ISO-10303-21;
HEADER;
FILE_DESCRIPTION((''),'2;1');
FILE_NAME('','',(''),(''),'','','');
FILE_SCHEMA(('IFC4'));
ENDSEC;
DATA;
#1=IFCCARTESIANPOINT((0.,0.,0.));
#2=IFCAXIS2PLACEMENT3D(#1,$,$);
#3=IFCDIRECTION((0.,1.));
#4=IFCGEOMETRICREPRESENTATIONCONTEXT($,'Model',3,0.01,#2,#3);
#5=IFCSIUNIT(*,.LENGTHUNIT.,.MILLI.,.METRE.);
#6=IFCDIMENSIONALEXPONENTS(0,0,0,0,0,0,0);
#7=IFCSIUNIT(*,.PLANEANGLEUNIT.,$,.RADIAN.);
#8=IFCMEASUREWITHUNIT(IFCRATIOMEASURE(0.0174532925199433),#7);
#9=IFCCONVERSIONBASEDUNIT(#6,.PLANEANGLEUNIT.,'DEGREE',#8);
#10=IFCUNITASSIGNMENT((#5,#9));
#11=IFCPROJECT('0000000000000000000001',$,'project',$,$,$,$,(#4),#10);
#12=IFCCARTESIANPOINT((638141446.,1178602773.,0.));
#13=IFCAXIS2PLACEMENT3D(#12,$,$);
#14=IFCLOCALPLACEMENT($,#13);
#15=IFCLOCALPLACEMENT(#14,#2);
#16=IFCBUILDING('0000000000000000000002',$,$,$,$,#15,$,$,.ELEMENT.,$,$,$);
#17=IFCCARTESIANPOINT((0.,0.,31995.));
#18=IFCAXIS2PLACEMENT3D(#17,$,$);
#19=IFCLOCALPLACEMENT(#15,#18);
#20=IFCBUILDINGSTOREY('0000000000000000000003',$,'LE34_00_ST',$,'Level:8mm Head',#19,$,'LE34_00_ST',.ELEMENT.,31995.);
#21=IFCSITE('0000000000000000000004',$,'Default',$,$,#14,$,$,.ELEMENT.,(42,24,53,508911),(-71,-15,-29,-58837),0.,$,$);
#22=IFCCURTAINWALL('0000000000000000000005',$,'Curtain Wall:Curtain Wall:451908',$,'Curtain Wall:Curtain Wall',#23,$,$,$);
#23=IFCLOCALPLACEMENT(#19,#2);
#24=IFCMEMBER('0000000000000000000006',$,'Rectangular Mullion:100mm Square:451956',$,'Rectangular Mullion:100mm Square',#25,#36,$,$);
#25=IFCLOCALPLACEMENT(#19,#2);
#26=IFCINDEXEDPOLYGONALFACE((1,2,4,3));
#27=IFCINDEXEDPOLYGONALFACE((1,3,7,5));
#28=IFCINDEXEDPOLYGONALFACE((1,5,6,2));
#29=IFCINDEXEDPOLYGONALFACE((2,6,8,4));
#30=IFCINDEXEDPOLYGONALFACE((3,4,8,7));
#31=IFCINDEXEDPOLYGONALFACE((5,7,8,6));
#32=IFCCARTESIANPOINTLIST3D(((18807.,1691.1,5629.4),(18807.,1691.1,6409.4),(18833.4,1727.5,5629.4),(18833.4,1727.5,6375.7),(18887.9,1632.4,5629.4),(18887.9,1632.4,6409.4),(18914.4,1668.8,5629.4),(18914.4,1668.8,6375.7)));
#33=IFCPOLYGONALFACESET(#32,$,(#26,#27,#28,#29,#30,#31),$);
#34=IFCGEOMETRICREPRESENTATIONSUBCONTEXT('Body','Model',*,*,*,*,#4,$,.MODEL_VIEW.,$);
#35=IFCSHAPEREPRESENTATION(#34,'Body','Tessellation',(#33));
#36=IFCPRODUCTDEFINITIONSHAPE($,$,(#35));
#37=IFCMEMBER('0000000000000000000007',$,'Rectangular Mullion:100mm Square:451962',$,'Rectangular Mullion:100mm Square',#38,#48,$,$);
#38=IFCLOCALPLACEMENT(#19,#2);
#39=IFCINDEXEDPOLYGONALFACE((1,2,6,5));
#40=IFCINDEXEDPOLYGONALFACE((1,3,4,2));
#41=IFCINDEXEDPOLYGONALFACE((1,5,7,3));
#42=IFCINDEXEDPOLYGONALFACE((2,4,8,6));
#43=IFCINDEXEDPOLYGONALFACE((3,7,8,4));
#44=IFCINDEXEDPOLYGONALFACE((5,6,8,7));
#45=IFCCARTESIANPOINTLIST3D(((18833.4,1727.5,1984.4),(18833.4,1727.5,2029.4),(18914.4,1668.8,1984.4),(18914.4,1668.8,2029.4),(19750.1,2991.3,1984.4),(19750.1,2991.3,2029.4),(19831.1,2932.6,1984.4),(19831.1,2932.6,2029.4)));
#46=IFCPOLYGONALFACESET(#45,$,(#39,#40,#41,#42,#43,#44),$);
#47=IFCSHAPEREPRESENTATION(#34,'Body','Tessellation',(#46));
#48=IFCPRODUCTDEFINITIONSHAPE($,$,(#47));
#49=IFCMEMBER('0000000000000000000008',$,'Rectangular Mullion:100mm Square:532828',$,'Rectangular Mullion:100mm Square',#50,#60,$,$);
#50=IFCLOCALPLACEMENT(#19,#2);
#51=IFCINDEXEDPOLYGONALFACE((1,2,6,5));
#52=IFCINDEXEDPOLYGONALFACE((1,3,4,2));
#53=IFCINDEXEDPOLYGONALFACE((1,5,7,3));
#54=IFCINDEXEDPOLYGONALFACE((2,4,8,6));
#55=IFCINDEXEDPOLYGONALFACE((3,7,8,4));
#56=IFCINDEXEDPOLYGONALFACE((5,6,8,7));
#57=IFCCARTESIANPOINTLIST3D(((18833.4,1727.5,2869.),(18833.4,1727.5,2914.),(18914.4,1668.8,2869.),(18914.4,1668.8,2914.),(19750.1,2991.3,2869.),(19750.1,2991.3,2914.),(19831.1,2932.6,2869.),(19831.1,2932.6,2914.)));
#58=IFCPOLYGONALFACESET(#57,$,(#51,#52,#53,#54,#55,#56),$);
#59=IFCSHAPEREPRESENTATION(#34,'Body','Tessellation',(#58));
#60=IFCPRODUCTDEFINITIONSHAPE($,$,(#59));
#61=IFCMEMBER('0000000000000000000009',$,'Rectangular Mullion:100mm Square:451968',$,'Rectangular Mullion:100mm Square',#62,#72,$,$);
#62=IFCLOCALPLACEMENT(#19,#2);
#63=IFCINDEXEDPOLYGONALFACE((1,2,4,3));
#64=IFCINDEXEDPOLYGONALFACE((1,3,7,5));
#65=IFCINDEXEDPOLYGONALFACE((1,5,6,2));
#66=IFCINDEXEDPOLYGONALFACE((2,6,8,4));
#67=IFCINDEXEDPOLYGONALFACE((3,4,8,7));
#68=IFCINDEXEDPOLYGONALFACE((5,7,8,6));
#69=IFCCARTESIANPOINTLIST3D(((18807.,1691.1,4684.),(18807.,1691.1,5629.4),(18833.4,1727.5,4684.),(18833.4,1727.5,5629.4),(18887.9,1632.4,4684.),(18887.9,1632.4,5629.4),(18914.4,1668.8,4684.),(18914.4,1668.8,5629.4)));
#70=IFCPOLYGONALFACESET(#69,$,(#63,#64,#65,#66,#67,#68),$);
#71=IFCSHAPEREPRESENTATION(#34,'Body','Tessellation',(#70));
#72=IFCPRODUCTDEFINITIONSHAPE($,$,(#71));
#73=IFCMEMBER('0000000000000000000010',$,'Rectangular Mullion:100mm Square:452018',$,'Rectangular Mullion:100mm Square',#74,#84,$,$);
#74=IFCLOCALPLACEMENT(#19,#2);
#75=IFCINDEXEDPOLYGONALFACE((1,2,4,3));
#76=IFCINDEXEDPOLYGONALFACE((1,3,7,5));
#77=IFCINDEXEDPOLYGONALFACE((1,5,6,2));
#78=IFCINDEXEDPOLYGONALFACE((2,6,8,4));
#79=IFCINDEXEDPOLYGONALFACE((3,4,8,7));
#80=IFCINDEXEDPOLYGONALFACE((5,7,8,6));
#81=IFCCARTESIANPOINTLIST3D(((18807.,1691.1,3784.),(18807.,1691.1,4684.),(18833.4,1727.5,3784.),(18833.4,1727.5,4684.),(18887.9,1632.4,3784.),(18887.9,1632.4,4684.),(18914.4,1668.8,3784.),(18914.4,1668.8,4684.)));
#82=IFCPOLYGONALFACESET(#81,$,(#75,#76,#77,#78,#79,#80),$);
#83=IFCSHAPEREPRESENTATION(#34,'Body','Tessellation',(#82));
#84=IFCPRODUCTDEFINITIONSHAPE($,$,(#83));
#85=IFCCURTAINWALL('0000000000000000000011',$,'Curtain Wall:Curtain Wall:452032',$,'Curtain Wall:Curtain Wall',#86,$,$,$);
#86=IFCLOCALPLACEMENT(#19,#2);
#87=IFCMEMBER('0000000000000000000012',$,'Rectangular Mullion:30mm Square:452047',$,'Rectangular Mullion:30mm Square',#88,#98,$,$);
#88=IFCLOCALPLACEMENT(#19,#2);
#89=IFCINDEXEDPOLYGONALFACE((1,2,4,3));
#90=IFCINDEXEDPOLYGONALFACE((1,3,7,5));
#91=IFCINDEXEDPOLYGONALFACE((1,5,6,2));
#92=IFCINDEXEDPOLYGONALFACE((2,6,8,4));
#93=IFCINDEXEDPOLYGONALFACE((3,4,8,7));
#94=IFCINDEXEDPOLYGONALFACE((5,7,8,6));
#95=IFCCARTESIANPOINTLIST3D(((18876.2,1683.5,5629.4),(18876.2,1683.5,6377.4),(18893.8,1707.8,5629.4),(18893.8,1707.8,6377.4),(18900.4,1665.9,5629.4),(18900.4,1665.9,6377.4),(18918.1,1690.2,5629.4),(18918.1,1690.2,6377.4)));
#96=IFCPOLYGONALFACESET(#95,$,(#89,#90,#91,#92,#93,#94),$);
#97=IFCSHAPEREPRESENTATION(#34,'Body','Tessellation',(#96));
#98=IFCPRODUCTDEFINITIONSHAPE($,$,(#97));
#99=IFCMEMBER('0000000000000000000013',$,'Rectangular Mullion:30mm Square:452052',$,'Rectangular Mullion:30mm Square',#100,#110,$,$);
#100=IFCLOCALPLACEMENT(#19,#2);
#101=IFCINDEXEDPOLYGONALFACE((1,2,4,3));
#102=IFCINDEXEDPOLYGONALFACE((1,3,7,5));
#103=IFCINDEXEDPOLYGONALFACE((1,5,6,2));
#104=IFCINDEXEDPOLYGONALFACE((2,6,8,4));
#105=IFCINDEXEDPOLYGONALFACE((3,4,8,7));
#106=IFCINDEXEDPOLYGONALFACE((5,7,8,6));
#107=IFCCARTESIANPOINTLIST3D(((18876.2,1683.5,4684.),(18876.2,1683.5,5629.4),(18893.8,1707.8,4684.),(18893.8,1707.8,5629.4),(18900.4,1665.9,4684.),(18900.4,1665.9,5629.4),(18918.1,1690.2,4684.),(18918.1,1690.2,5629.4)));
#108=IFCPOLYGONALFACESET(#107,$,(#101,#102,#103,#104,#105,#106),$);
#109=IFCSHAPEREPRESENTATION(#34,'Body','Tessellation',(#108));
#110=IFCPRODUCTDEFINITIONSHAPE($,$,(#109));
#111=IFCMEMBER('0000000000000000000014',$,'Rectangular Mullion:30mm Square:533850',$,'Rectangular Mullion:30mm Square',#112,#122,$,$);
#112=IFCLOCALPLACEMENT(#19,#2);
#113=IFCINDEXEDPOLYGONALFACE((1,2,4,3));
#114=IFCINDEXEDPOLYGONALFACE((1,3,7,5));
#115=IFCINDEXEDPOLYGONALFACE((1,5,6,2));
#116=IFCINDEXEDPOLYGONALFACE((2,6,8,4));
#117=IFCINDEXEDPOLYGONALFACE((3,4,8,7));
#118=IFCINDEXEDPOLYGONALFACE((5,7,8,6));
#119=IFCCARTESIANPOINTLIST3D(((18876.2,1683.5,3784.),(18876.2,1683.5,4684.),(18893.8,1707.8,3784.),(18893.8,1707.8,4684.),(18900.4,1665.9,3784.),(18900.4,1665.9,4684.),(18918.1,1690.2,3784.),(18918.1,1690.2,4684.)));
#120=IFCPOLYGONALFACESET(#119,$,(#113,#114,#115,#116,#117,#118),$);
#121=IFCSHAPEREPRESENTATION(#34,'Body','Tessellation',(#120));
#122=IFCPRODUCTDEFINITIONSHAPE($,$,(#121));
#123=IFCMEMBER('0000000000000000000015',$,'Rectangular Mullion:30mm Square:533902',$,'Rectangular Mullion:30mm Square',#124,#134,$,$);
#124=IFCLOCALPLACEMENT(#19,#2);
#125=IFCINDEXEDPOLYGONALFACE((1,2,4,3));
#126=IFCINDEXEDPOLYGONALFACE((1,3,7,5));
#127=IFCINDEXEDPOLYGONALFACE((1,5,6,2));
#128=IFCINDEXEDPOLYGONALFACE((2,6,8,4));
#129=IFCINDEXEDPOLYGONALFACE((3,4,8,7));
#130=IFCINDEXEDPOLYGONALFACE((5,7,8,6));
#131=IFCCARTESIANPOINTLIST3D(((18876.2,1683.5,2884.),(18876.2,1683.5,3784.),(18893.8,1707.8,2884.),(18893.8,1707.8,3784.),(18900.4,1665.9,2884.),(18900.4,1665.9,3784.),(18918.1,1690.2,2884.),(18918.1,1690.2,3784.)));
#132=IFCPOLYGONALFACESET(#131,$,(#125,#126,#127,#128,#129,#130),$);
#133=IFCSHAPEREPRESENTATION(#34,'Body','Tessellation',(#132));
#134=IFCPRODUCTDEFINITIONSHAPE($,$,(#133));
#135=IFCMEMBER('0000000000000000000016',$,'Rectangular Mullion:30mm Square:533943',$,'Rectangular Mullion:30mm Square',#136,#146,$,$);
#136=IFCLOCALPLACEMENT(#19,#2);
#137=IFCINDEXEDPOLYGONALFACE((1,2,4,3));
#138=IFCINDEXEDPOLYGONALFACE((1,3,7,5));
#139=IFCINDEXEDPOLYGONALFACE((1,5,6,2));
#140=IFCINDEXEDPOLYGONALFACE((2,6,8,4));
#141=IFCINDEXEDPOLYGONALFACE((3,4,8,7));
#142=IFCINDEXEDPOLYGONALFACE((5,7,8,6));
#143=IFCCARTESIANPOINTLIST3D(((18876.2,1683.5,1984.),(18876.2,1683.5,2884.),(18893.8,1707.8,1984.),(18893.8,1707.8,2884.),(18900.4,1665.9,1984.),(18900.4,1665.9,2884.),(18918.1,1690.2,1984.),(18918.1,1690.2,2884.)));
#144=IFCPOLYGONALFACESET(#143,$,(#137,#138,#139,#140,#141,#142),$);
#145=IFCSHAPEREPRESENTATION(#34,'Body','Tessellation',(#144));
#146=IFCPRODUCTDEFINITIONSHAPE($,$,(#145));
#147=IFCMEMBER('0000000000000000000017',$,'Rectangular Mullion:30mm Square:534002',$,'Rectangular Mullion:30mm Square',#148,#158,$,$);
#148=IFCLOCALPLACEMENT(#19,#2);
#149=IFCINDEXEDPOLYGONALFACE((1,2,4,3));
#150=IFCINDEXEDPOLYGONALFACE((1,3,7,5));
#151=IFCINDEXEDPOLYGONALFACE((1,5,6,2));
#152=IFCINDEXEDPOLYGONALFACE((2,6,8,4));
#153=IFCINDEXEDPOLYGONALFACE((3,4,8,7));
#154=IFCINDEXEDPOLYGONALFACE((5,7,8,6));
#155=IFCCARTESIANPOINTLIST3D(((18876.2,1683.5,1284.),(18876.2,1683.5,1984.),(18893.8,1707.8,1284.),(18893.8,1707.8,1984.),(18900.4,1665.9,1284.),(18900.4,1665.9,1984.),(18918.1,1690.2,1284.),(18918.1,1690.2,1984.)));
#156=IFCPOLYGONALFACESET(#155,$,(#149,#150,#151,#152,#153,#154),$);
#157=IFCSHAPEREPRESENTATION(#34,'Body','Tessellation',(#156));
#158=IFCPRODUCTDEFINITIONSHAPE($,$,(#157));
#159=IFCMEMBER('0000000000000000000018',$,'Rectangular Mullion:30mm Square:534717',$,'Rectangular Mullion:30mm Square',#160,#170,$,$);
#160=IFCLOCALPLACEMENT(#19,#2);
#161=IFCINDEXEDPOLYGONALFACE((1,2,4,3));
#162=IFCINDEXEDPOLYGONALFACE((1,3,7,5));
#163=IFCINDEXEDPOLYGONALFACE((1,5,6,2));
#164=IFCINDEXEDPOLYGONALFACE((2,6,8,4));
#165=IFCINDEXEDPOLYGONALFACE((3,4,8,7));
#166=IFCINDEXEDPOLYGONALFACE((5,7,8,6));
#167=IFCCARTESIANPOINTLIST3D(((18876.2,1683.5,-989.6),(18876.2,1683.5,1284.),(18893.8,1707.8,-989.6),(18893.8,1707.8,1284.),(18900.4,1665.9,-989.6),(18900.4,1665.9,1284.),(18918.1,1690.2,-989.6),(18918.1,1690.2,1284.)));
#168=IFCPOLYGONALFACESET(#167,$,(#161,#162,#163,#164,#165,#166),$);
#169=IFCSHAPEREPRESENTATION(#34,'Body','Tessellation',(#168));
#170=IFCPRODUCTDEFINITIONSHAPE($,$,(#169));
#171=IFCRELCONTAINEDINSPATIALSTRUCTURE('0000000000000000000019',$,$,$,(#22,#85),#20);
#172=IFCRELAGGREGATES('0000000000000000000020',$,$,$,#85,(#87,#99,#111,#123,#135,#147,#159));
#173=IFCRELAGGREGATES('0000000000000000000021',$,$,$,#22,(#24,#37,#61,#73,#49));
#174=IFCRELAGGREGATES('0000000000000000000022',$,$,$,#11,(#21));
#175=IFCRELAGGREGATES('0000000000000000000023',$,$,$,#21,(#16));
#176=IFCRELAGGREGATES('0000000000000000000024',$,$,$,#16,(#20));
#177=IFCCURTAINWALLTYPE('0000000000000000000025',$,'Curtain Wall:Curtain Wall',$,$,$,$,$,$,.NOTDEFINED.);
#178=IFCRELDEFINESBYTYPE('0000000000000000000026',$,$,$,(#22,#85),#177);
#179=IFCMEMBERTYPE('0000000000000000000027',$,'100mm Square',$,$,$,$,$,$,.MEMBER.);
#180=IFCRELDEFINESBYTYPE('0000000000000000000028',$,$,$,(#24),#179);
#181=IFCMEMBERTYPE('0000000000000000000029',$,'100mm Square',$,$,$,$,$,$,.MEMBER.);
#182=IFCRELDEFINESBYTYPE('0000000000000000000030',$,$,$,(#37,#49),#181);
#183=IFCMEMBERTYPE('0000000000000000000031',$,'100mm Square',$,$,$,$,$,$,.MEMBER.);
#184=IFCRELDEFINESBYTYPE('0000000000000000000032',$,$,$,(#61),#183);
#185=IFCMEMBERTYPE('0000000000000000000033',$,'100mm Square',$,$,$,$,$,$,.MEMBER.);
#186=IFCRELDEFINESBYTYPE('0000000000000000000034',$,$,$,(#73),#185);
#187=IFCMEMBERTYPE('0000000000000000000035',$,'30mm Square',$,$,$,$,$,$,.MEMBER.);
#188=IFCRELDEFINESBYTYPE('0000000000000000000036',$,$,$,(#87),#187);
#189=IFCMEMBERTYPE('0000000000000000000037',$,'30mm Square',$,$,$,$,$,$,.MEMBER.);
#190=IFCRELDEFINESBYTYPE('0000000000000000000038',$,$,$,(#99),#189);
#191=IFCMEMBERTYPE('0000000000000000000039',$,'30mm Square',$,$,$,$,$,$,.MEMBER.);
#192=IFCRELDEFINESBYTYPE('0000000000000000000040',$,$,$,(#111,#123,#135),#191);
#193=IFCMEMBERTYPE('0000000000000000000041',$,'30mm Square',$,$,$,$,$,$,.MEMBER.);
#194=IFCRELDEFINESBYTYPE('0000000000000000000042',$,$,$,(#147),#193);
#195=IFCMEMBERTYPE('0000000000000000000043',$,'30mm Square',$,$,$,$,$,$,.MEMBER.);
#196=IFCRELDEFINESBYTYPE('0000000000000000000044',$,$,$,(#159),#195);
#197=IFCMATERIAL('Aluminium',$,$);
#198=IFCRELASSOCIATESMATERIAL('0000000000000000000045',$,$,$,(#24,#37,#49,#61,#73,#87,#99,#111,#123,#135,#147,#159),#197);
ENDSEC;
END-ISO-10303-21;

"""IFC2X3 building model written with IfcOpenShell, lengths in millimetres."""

from ifc_helpers import new_model, entity, si_unit, converted_unit, direction, frame, origin, origin_2d_with_axis, place, context, subcontext, project, spatial, rectangle, extrude, clip, halfspace, source, transform, mapped, material, type_object, type_shapes, element, aggregate, save


model = new_model("IFC2X3")

# Units and contexts
model_context = context("Model", 3, precision=0.01, world=origin(), true_north=direction((0.0, 1.0)))
body_context = subcontext(model_context, "Body", "Model", "MODEL_VIEW")
ifc_project = project(units=[si_unit("LENGTHUNIT", "METRE", prefix="MILLI"), converted_unit("PLANEANGLEUNIT", "DEGREE", entity("IfcRatioMeasure", 0.0174532925199433), si_unit("PLANEANGLEUNIT", "RADIAN"), dimensions=[0, 0, 0, 0, 0, 0, 0])], contexts=[model_context])

# Site, building, storey
site_placement = place(None, frame((638141446.0, 1178602773.0, 0.0)))
site = spatial("IfcSite", under=ifc_project, at=site_placement, Name="Default", CompositionType="ELEMENT", RefLatitude=(42, 24, 53, 508911), RefLongitude=(-71, -15, -29, -58837), RefElevation=0.0)
building_placement = place(site_placement, origin())
building = spatial("IfcBuilding", under=site, at=building_placement, CompositionType="ELEMENT")
storey_placement = place(building_placement, frame((0.0, 0.0, 31995.0)))
storey = spatial("IfcBuildingStorey", under=building, at=storey_placement, Name="LE34_00_ST", ObjectType="Level:8mm Head", LongName="LE34_00_ST", CompositionType="ELEMENT", Elevation=31995.0)

# Curtain walls, members
curtain_wall_type = type_object("IfcCurtainWallType", Name="Curtain Wall:Curtain Wall", PredefinedType="NOTDEFINED")
curtain_wall_1_placement = place(storey_placement, frame((0.0, 0.0, -31995.0)))
curtain_wall_1 = element("IfcCurtainWall", 1, at=curtain_wall_1_placement, inside=storey, type_object=curtain_wall_type, Name="Curtain Wall:Curtain Wall:451908", ObjectType="Curtain Wall:Curtain Wall")
ifc_material_1 = material(Name="Aluminium")
member_type_1 = type_object("IfcMemberType", Name="100mm Square", PredefinedType="MEMBER")
shared_shape_1 = source(origin(), body_context, "Body", "Clipping", [
    clip(extrude(rectangle(XDim=100.0, YDim=45.0, at=origin_2d_with_axis()), frame((-22.5, 0.0, -780.0), z_axis=(0.0, 0.0, 1.0), x_axis=(0.0, -1.0, 0.0)), (0.0, 0.0, 1.0), 780.0), halfspace(frame((0.0, -304.8, 0.0), z_axis=(-0.599555, 0.0, 0.800333), x_axis=(-0.800333, 0.0, -0.599555)), False)),
])
type_shapes(member_type_1, [shared_shape_1])
member_1_placement = place(storey_placement, frame((18847.5, 1661.7, 6409.4), z_axis=(0.0, 0.0, 1.0), x_axis=(-0.587164, -0.809468, 0.0)))
member_1 = element("IfcMember", 2, at=member_1_placement, type_object=member_type_1, material=ifc_material_1, Name="Rectangular Mullion:100mm Square:451956", ObjectType="Rectangular Mullion:100mm Square", context=body_context, shape_type="MappedRepresentation", body=[
    mapped(shared_shape_1, transform((0.0, 0.0, 0.0), scale=1.0)),
])
member_type_2 = type_object("IfcMemberType", Name="100mm Square", PredefinedType="MEMBER")
shared_shape_2 = source(origin(), body_context, "Body", "SweptSolid", [
    extrude(rectangle(XDim=100.0, YDim=45.0, at=origin_2d_with_axis()), frame((7.5, 0.0, -1561.3), z_axis=(0.0, 0.0, 1.0), x_axis=(0.0, -1.0, 0.0)), (0.0, 0.0, 1.0), 1561.3),
])
type_shapes(member_type_2, [shared_shape_2])
member_2_placement = place(storey_placement, frame((19790.6, 2962.0, 1999.4), z_axis=(0.587164, 0.809468, 0.0), x_axis=(0.0, 0.0, 1.0)))
member_2 = element("IfcMember", 3, at=member_2_placement, type_object=member_type_2, material=ifc_material_1, Name="Rectangular Mullion:100mm Square:451962", ObjectType="Rectangular Mullion:100mm Square", context=body_context, shape_type="MappedRepresentation", body=[
    mapped(shared_shape_2, transform((0.0, 0.0, 0.0), scale=1.0)),
])
member_3_placement = place(storey_placement, frame((19790.6, 2962.0, 2884.0), z_axis=(0.587164, 0.809468, 0.0), x_axis=(0.0, 0.0, 1.0)))
member_3 = element("IfcMember", 4, at=member_3_placement, type_object=member_type_2, material=ifc_material_1, Name="Rectangular Mullion:100mm Square:532828", ObjectType="Rectangular Mullion:100mm Square", context=body_context, shape_type="MappedRepresentation", body=[
    mapped(shared_shape_2, transform((0.0, 0.0, 0.0), scale=1.0)),
])
member_type_3 = type_object("IfcMemberType", Name="100mm Square", PredefinedType="MEMBER")
shared_shape_3 = source(origin(), body_context, "Body", "SweptSolid", [
    extrude(rectangle(XDim=100.0, YDim=45.0, at=origin_2d_with_axis()), frame((-22.5, 0.0, -945.4), z_axis=(0.0, 0.0, 1.0), x_axis=(0.0, -1.0, 0.0)), (0.0, 0.0, 1.0), 945.4),
])
type_shapes(member_type_3, [shared_shape_3])
member_4_placement = place(storey_placement, frame((18847.5, 1661.7, 5629.4), z_axis=(0.0, 0.0, 1.0), x_axis=(-0.587164, -0.809468, 0.0)))
member_4 = element("IfcMember", 5, at=member_4_placement, type_object=member_type_3, material=ifc_material_1, Name="Rectangular Mullion:100mm Square:451968", ObjectType="Rectangular Mullion:100mm Square", context=body_context, shape_type="MappedRepresentation", body=[
    mapped(shared_shape_3, transform((0.0, 0.0, 0.0), scale=1.0)),
])
member_type_4 = type_object("IfcMemberType", Name="100mm Square", PredefinedType="MEMBER")
shared_shape_4 = source(origin(), body_context, "Body", "SweptSolid", [
    extrude(rectangle(XDim=100.0, YDim=45.0, at=origin_2d_with_axis()), frame((-22.5, 0.0, -900.0), z_axis=(0.0, 0.0, 1.0), x_axis=(0.0, -1.0, 0.0)), (0.0, 0.0, 1.0), 900.0),
])
type_shapes(member_type_4, [shared_shape_4])
member_5_placement = place(storey_placement, frame((18847.5, 1661.7, 4684.0), z_axis=(0.0, 0.0, 1.0), x_axis=(-0.587164, -0.809468, 0.0)))
member_5 = element("IfcMember", 6, at=member_5_placement, type_object=member_type_4, material=ifc_material_1, Name="Rectangular Mullion:100mm Square:452018", ObjectType="Rectangular Mullion:100mm Square", context=body_context, shape_type="MappedRepresentation", body=[
    mapped(shared_shape_4, transform((0.0, 0.0, 0.0), scale=1.0)),
])
curtain_wall_2_placement = place(storey_placement, frame((0.0, 0.0, -31995.0)))
curtain_wall_2 = element("IfcCurtainWall", 7, at=curtain_wall_2_placement, inside=storey, type_object=curtain_wall_type, Name="Curtain Wall:Curtain Wall:452032", ObjectType="Curtain Wall:Curtain Wall")
member_type_5 = type_object("IfcMemberType", Name="30mm Square", PredefinedType="MEMBER")
shared_shape_5 = source(origin(), body_context, "Body", "SweptSolid", [
    extrude(rectangle(XDim=30.0, YDim=30.0, at=origin_2d_with_axis()), frame((-15.0, 0.0, -748.0), z_axis=(0.0, 0.0, 1.0), x_axis=(0.0, -1.0, 0.0)), (0.0, 0.0, 1.0), 748.0),
])
type_shapes(member_type_5, [shared_shape_5])
member_6_placement = place(storey_placement, frame((18909.2, 1678.1, 6377.4), z_axis=(0.0, 0.0, 1.0), x_axis=(0.809468, -0.587164, 0.0)))
member_6 = element("IfcMember", 8, at=member_6_placement, type_object=member_type_5, material=ifc_material_1, Name="Rectangular Mullion:30mm Square:452047", ObjectType="Rectangular Mullion:30mm Square", context=body_context, shape_type="MappedRepresentation", body=[
    mapped(shared_shape_5, transform((0.0, 0.0, 0.0), scale=1.0)),
])
member_type_6 = type_object("IfcMemberType", Name="30mm Square", PredefinedType="MEMBER")
shared_shape_6 = source(origin(), body_context, "Body", "SweptSolid", [
    extrude(rectangle(XDim=30.0, YDim=30.0, at=origin_2d_with_axis()), frame((-15.0, 0.0, -945.4), z_axis=(0.0, 0.0, 1.0), x_axis=(0.0, -1.0, 0.0)), (0.0, 0.0, 1.0), 945.4),
])
type_shapes(member_type_6, [shared_shape_6])
member_7_placement = place(storey_placement, frame((18909.2, 1678.1, 5629.4), z_axis=(0.0, 0.0, 1.0), x_axis=(0.809468, -0.587164, 0.0)))
member_7 = element("IfcMember", 9, at=member_7_placement, type_object=member_type_6, material=ifc_material_1, Name="Rectangular Mullion:30mm Square:452052", ObjectType="Rectangular Mullion:30mm Square", context=body_context, shape_type="MappedRepresentation", body=[
    mapped(shared_shape_6, transform((0.0, 0.0, 0.0), scale=1.0)),
])
member_type_7 = type_object("IfcMemberType", Name="30mm Square", PredefinedType="MEMBER")
shared_shape_7 = source(origin(), body_context, "Body", "SweptSolid", [
    extrude(rectangle(XDim=30.0, YDim=30.0, at=origin_2d_with_axis()), frame((-15.0, 0.0, -900.0), z_axis=(0.0, 0.0, 1.0), x_axis=(0.0, -1.0, 0.0)), (0.0, 0.0, 1.0), 900.0),
])
type_shapes(member_type_7, [shared_shape_7])
member_8_placement = place(storey_placement, frame((18909.2, 1678.1, 4684.0), z_axis=(0.0, 0.0, 1.0), x_axis=(0.809468, -0.587164, 0.0)))
member_8 = element("IfcMember", 10, at=member_8_placement, type_object=member_type_7, material=ifc_material_1, Name="Rectangular Mullion:30mm Square:533850", ObjectType="Rectangular Mullion:30mm Square", context=body_context, shape_type="MappedRepresentation", body=[
    mapped(shared_shape_7, transform((0.0, 0.0, 0.0), scale=1.0)),
])
member_9_placement = place(storey_placement, frame((18909.2, 1678.1, 3784.0), z_axis=(0.0, 0.0, 1.0), x_axis=(0.809468, -0.587164, 0.0)))
member_9 = element("IfcMember", 11, at=member_9_placement, type_object=member_type_7, material=ifc_material_1, Name="Rectangular Mullion:30mm Square:533902", ObjectType="Rectangular Mullion:30mm Square", context=body_context, shape_type="MappedRepresentation", body=[
    mapped(shared_shape_7, transform((0.0, 0.0, 0.0), scale=1.0)),
])
member_10_placement = place(storey_placement, frame((18909.2, 1678.1, 2884.0), z_axis=(0.0, 0.0, 1.0), x_axis=(0.809468, -0.587164, 0.0)))
member_10 = element("IfcMember", 12, at=member_10_placement, type_object=member_type_7, material=ifc_material_1, Name="Rectangular Mullion:30mm Square:533943", ObjectType="Rectangular Mullion:30mm Square", context=body_context, shape_type="MappedRepresentation", body=[
    mapped(shared_shape_7, transform((0.0, 0.0, 0.0), scale=1.0)),
])
member_type_8 = type_object("IfcMemberType", Name="30mm Square", PredefinedType="MEMBER")
shared_shape_8 = source(origin(), body_context, "Body", "SweptSolid", [
    extrude(rectangle(XDim=30.0, YDim=30.0, at=origin_2d_with_axis()), frame((-15.0, 0.0, -700.0), z_axis=(0.0, 0.0, 1.0), x_axis=(0.0, -1.0, 0.0)), (0.0, 0.0, 1.0), 700.0),
])
type_shapes(member_type_8, [shared_shape_8])
member_11_placement = place(storey_placement, frame((18909.2, 1678.1, 1984.0), z_axis=(0.0, 0.0, 1.0), x_axis=(0.809468, -0.587164, 0.0)))
member_11 = element("IfcMember", 13, at=member_11_placement, type_object=member_type_8, material=ifc_material_1, Name="Rectangular Mullion:30mm Square:534002", ObjectType="Rectangular Mullion:30mm Square", context=body_context, shape_type="MappedRepresentation", body=[
    mapped(shared_shape_8, transform((0.0, 0.0, 0.0), scale=1.0)),
])
member_type_9 = type_object("IfcMemberType", Name="30mm Square", PredefinedType="MEMBER")
shared_shape_9 = source(origin(), body_context, "Body", "SweptSolid", [
    extrude(rectangle(XDim=30.0, YDim=30.0, at=origin_2d_with_axis()), frame((-15.0, 0.0, -2273.6), z_axis=(0.0, 0.0, 1.0), x_axis=(0.0, -1.0, 0.0)), (0.0, 0.0, 1.0), 2273.6),
])
type_shapes(member_type_9, [shared_shape_9])
member_12_placement = place(storey_placement, frame((18909.2, 1678.1, 1284.0), z_axis=(0.0, 0.0, 1.0), x_axis=(0.809468, -0.587164, 0.0)))
member_12 = element("IfcMember", 14, at=member_12_placement, type_object=member_type_9, material=ifc_material_1, Name="Rectangular Mullion:30mm Square:534717", ObjectType="Rectangular Mullion:30mm Square", context=body_context, shape_type="MappedRepresentation", body=[
    mapped(shared_shape_9, transform((0.0, 0.0, 0.0), scale=1.0)),
])
aggregate(curtain_wall_2, [member_6, member_7, member_8, member_9, member_10, member_11, member_12])

aggregate(curtain_wall_1, [member_1, member_2, member_4, member_5, member_3])

save(model, "model.ifc")
